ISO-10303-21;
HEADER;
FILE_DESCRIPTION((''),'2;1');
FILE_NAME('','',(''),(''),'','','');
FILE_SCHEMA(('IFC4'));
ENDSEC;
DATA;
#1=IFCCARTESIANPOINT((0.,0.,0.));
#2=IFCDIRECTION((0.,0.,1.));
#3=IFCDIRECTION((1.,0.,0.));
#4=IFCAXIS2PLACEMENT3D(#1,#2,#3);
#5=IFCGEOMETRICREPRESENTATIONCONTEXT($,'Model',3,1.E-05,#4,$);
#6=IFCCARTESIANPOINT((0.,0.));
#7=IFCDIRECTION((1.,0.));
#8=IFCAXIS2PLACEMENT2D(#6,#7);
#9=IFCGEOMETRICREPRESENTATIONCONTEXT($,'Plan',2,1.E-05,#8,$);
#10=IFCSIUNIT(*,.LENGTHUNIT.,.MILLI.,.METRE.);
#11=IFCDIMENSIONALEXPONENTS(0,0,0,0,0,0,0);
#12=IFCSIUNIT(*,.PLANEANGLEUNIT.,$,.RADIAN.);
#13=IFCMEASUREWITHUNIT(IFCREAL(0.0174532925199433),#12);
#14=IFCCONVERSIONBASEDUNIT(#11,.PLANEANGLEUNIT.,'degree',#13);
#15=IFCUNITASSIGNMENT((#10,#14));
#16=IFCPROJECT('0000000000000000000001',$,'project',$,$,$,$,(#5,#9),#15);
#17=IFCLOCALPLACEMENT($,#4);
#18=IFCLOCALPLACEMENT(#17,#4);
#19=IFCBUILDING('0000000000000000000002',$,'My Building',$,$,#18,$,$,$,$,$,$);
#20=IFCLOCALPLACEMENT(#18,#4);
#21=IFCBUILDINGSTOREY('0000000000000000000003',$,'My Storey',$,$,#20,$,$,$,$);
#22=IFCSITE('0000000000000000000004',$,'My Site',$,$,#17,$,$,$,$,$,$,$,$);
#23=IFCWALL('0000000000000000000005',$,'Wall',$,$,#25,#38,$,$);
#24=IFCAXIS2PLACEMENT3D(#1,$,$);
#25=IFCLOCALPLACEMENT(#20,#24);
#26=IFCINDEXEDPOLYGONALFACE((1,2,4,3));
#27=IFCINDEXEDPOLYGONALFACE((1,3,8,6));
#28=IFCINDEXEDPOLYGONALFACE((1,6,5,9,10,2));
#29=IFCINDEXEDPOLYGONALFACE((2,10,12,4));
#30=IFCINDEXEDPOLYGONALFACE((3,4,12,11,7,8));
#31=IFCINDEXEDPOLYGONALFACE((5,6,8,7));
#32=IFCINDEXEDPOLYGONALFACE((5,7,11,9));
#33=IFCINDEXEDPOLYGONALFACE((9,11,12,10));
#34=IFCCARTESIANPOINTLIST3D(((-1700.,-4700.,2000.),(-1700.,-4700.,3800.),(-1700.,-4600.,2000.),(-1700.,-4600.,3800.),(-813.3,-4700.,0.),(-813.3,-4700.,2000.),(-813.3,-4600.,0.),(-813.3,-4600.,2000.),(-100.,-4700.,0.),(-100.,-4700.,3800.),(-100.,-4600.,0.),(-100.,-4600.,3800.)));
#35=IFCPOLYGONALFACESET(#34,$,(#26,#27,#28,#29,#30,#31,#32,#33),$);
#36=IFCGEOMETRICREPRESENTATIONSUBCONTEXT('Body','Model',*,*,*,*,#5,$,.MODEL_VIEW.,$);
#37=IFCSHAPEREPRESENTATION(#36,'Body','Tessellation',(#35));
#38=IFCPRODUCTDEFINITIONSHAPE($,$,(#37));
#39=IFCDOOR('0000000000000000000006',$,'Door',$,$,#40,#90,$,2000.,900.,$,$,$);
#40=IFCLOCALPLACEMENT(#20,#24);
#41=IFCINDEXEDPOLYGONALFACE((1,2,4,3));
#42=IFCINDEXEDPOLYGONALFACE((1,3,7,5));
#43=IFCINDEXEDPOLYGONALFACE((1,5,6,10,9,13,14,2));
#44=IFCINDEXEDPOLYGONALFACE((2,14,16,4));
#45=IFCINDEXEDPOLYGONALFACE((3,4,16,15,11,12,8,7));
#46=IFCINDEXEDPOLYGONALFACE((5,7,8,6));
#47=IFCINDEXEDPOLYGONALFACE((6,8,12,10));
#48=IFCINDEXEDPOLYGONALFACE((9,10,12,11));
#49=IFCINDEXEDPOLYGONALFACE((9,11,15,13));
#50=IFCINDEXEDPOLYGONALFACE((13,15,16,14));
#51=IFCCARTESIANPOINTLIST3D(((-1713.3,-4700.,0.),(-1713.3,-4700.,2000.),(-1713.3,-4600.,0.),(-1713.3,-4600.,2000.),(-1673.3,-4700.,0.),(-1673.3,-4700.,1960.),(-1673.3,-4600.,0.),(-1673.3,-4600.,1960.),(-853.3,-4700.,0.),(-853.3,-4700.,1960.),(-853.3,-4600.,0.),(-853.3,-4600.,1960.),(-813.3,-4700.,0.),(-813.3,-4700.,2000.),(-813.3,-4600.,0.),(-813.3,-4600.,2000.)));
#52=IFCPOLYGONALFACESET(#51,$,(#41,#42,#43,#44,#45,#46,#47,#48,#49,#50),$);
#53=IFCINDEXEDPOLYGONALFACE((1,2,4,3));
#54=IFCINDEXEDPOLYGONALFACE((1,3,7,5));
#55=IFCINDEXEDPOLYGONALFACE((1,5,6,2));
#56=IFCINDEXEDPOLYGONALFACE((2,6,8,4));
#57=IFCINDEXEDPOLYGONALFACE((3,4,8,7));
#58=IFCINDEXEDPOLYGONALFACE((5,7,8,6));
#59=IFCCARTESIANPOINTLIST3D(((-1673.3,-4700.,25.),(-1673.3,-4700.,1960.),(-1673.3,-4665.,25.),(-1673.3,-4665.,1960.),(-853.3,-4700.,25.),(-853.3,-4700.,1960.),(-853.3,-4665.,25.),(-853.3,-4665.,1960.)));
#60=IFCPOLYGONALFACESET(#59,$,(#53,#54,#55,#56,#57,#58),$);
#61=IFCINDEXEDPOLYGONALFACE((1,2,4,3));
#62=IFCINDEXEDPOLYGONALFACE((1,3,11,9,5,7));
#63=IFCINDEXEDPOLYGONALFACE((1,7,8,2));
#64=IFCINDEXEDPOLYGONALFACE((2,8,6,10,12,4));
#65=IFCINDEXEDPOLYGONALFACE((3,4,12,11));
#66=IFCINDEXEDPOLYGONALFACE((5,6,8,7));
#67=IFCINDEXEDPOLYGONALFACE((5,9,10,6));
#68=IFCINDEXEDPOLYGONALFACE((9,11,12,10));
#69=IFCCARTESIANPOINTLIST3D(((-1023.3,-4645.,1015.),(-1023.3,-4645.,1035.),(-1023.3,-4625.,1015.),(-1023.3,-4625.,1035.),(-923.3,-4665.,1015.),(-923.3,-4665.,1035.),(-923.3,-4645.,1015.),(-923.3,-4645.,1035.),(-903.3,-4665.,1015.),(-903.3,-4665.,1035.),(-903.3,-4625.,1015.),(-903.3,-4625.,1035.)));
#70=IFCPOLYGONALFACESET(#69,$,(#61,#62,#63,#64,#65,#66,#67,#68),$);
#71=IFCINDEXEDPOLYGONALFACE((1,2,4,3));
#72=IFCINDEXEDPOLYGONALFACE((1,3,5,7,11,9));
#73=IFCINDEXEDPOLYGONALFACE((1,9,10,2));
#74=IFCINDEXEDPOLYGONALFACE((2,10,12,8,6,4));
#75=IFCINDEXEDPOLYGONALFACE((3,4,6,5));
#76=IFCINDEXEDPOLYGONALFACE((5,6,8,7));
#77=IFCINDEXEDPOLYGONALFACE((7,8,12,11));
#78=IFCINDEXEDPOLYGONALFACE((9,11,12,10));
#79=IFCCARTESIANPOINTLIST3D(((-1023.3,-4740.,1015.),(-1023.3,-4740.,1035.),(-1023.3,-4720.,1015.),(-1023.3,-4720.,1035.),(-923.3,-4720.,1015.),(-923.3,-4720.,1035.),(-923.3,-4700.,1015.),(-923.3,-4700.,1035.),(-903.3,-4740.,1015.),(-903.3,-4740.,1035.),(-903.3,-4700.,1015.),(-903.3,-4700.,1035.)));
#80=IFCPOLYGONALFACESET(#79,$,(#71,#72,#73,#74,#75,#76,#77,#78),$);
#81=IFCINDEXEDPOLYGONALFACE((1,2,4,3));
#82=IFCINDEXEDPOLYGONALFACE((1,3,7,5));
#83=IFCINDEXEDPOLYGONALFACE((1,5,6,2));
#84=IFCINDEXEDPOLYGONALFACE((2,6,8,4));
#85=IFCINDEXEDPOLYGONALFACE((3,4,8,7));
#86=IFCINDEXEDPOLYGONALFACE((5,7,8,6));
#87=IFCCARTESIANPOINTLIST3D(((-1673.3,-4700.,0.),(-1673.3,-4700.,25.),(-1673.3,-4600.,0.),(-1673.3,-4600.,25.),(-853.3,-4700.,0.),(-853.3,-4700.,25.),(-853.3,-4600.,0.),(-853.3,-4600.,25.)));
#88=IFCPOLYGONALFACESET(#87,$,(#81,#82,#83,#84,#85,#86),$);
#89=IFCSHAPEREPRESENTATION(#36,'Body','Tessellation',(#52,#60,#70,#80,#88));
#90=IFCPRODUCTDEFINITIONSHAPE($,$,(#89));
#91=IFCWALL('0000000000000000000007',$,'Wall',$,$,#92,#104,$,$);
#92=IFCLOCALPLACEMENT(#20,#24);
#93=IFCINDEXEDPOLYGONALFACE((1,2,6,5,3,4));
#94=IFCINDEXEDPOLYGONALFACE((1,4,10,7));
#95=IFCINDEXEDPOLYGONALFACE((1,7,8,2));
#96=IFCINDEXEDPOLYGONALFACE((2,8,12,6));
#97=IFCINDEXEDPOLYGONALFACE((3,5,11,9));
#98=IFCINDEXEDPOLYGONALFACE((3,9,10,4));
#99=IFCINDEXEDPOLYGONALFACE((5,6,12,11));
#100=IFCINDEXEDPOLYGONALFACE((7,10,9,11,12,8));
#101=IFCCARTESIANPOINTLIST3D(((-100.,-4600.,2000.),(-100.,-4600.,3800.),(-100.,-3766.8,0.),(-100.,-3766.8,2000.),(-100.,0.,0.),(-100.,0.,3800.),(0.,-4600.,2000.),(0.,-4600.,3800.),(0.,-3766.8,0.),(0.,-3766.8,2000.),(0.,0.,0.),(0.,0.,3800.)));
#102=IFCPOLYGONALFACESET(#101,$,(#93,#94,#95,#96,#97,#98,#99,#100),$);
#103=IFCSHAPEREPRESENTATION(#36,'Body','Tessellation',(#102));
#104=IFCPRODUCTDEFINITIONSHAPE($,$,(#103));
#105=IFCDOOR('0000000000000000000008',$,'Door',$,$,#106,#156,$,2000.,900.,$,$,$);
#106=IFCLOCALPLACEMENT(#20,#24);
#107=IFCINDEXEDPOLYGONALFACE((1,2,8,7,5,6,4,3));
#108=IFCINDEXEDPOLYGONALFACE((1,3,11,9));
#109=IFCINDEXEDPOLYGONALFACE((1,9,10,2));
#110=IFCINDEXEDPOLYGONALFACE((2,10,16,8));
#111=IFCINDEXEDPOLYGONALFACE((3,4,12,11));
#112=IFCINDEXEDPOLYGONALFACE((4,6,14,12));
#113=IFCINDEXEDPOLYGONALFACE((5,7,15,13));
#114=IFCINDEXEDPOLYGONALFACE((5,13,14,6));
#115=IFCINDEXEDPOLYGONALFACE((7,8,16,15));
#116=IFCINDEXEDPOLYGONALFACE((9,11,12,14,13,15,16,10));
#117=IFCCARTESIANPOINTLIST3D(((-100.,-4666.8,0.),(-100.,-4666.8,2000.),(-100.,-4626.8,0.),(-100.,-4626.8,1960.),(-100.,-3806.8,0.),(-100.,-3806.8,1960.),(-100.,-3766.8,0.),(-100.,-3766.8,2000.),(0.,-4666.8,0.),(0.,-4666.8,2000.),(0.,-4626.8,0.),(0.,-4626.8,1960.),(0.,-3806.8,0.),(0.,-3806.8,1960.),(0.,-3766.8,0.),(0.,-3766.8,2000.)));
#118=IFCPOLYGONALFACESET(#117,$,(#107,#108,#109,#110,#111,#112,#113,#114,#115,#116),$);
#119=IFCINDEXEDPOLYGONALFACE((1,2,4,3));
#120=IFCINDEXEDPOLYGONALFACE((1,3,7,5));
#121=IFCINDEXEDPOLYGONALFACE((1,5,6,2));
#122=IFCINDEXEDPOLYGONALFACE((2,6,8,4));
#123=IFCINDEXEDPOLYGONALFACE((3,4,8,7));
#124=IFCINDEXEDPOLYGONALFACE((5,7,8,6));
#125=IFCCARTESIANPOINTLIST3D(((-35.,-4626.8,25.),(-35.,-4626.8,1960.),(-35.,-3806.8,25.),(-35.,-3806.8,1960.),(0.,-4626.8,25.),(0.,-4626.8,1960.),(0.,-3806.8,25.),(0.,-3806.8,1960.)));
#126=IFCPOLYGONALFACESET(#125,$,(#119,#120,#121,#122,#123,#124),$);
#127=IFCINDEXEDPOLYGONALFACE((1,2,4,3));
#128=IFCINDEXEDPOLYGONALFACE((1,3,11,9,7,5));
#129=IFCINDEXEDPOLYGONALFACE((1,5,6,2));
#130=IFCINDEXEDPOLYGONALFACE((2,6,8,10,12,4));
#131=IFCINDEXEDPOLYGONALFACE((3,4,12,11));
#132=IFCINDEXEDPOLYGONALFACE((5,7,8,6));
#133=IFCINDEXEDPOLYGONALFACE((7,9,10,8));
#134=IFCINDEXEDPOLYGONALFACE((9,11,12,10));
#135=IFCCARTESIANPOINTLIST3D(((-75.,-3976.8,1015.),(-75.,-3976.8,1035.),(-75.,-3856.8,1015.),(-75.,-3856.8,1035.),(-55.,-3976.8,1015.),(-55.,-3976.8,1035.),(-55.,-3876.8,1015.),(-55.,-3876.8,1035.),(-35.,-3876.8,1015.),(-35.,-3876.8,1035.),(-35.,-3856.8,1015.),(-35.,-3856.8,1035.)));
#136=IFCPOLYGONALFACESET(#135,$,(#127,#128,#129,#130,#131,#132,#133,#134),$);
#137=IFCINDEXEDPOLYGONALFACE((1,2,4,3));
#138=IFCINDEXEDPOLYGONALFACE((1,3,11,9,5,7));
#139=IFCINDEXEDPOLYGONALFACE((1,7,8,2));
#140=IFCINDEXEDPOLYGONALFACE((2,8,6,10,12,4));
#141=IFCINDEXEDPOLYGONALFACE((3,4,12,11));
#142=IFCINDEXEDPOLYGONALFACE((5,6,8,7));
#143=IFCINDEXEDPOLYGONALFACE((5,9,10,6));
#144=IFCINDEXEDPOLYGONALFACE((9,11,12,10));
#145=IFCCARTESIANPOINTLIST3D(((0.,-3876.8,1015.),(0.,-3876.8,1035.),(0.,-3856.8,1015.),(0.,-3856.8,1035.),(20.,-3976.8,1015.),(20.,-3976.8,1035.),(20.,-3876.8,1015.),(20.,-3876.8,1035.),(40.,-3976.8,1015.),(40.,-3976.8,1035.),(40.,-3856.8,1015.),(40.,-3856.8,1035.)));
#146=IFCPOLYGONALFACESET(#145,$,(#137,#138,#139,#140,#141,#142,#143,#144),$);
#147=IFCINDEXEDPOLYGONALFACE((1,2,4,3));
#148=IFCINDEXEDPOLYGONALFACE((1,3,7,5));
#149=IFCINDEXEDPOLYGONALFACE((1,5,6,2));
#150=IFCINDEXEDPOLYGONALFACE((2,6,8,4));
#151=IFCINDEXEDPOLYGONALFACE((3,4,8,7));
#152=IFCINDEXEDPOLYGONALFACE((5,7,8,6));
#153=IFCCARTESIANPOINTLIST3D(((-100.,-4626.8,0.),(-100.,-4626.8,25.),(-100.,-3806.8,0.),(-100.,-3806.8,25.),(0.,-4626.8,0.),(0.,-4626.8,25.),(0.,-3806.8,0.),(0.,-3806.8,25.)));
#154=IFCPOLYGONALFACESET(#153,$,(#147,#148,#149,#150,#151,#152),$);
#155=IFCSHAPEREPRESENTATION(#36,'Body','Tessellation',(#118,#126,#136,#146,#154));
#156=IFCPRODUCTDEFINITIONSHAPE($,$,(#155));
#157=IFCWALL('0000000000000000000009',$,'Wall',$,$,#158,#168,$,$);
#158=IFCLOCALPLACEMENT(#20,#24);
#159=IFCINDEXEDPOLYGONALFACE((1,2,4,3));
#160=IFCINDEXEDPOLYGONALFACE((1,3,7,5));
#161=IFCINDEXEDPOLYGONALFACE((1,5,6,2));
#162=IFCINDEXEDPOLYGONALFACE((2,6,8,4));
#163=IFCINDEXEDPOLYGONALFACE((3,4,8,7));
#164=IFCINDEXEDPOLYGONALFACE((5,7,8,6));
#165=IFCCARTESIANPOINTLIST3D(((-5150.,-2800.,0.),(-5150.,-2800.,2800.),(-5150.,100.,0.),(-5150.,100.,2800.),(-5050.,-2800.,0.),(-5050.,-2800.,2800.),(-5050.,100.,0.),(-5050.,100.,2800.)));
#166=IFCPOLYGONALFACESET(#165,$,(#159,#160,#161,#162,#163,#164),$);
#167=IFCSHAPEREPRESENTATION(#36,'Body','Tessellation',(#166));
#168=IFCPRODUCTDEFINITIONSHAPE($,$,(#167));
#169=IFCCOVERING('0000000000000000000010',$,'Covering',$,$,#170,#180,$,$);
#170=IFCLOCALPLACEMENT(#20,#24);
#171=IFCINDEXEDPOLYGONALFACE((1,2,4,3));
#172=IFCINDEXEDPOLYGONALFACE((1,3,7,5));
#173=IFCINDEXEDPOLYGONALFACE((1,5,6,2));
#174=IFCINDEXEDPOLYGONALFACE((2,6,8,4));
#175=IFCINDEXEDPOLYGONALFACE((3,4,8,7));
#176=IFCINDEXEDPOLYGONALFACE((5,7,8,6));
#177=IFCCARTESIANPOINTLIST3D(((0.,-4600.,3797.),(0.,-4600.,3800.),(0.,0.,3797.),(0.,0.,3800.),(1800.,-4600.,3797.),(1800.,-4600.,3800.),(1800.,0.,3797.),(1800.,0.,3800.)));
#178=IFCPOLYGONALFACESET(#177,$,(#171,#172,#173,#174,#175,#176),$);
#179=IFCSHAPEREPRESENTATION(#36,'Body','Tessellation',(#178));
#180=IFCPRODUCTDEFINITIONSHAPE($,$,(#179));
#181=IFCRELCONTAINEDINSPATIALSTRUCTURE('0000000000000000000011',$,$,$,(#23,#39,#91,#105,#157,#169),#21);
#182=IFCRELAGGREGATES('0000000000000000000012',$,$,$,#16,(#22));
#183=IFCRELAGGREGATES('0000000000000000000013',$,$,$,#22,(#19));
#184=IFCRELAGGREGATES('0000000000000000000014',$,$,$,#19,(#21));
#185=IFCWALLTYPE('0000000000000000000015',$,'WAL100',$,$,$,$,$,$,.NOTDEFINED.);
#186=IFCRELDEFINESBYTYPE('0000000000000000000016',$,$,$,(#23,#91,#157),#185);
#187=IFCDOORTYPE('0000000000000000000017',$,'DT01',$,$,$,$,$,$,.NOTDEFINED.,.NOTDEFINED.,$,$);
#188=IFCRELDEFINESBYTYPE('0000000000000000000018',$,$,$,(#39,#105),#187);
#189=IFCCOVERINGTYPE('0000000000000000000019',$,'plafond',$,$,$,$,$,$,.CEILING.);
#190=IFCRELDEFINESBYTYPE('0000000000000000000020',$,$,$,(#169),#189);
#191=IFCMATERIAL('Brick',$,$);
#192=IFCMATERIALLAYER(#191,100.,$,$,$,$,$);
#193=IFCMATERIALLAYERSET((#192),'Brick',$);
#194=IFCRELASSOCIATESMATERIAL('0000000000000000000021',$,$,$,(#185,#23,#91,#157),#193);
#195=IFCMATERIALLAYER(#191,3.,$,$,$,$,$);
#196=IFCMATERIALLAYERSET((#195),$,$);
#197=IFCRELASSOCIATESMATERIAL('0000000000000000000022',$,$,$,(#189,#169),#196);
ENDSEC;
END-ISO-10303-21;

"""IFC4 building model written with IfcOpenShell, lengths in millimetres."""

from ifc_helpers import new_model, entity, si_unit, converted_unit, frame, origin_with_axes, origin_2d_with_axis, place, context, subcontext, project, spatial, line, indexed_curve, outline, extrude, shape, source, transform, mapped, material, layer, layer_set, layer_usage, type_object, type_shapes, element, fill, save


model = new_model("IFC4")

# Units and contexts
model_context = context("Model", 3, precision=1e-05, world=origin_with_axes())
plan_context = context("Plan", 2, precision=1e-05, world=origin_2d_with_axis())
body_context_1 = subcontext(model_context, "Body", "Model", "MODEL_VIEW")
body_context_2 = subcontext(plan_context, "Body", "Plan", "PLAN_VIEW")
ifc_project = project(units=[si_unit("LENGTHUNIT", "METRE", prefix="MILLI"), converted_unit("PLANEANGLEUNIT", "degree", entity("IfcReal", 0.0174532925199433), si_unit("PLANEANGLEUNIT", "RADIAN"), dimensions=[0, 0, 0, 0, 0, 0, 0])], contexts=[model_context, plan_context])

# Site, building, storey
site_placement = place(None, origin_with_axes())
site = spatial("IfcSite", under=ifc_project, at=site_placement, Name="My Site")
building_placement = place(site_placement, origin_with_axes())
building = spatial("IfcBuilding", under=site, at=building_placement, Name="My Building")
storey_placement = place(building_placement, origin_with_axes())
storey = spatial("IfcBuildingStorey", under=building, at=storey_placement, Name="My Storey")

# Shared definitions
ifc_material = material(Name="Brick")
ifc_layer_1 = layer(ifc_material, 100.0)
ifc_layer_set_1 = layer_set([ifc_layer_1], Name="Brick")
wall_type = type_object("IfcWallType", Name="WAL100", PredefinedType="NOTDEFINED", material=ifc_layer_set_1)

# Shared definitions
shared_shape_1 = source(origin_with_axes(), body_context_1, "Body", "SweptSolid", [
    extrude(outline(indexed_curve([(0.0, 0.0), (900.0, 0.0), (900.0, 2000.0), (0.0, 2000.0)], segments=[line(1, 2, 3, 4, 1)])), frame((0.0, -100.0, 0.0), z_axis=(0.0, -1.0, 0.0), x_axis=(1.0, 0.0, 0.0)), (0.0, 0.0, -1.0), 300.0),
])
door_type_1 = type_object("IfcDoorType", Name="DT01", OperationType="NOTDEFINED", PredefinedType="NOTDEFINED")
shared_shape_2 = source(origin_with_axes(), body_context_1, "Body", "SweptSolid", [
    extrude(outline(indexed_curve([(0.0, 0.0), (0.0, 2000.0), (900.0, 2000.0), (900.0, 0.0), (860.0, 0.0), (860.0, 1960.0), (40.0, 1960.0), (40.0, 0.0)], segments=[line(1, 2, 3, 4, 5, 6, 7, 8, 1)])), frame((0.0, 0.0, 0.0), z_axis=(0.0, -1.0, 0.0), x_axis=(1.0, 0.0, 0.0)), (0.0, 0.0, -1.0), 100.0),
    extrude(outline(indexed_curve([(0.0, 0.0), (820.0, 0.0), (820.0, 35.0), (0.0, 35.0)], segments=[line(1, 2, 3, 4, 1)])), frame((40.0, 65.0, 25.0), z_axis=(0.0, 0.0, 1.0), x_axis=(1.0, 0.0, 0.0)), (0.0, 0.0, 1.0), 1935.0),
    extrude(outline(indexed_curve([(0.0, 0.0), (0.0, -40.0), (120.0, -40.0), (120.0, -20.0), (20.0, -20.0), (20.0, 0.0)], segments=[line(1, 2, 3, 4, 5, 6, 1)])), frame((90.0, 65.0, 1015.0), z_axis=(0.0, 0.0, 1.0), x_axis=(1.0, 0.0, 0.0)), (0.0, 0.0, 1.0), 20.0),
    extrude(outline(indexed_curve([(0.0, 0.0), (0.0, 40.0), (120.0, 40.0), (120.0, 20.0), (20.0, 20.0), (20.0, 0.0)], segments=[line(1, 2, 3, 4, 5, 6, 1)])), frame((90.0, 100.0, 1015.0), z_axis=(0.0, 0.0, 1.0), x_axis=(1.0, 0.0, 0.0)), (0.0, 0.0, 1.0), 20.0),
    extrude(outline(indexed_curve([(0.0, 0.0), (820.0, 0.0), (820.0, 100.0), (0.0, 100.0)], segments=[line(1, 2, 3, 4, 1)])), frame((40.0, 0.0, 0.0), z_axis=(0.0, 0.0, 1.0), x_axis=(1.0, 0.0, 0.0)), (0.0, 0.0, 1.0), 25.0),
])
shared_shape_3 = source(origin_with_axes(), body_context_2, "Body", "Curve2D", [
    entity("IfcIndexedPolyCurve", entity("IfcCartesianPointList2D", [[0.0, 0.0], [40.0, 0.0], [40.0, 100.0], [0.0, 100.0]]), [entity("IfcLineIndex", [1, 2, 3, 4, 1])]),
    entity("IfcIndexedPolyCurve", entity("IfcCartesianPointList2D", [[900.0, 0.0], [860.0, 0.0], [860.0, 100.0], [900.0, 100.0]]), [entity("IfcLineIndex", [1, 2, 3, 4, 1])]),
    entity("IfcTrimmedCurve", entity("IfcEllipse", entity("IfcAxis2Placement2D", entity("IfcCartesianPoint", [825.0, 100.0]), entity("IfcDirection", [1.0, 0.0])), 785.0, 820.0), [entity("IfcCartesianPoint", [825.0, 920.0])], [entity("IfcCartesianPoint", [40.0, 100.0])], True, "CARTESIAN"),
    entity("IfcIndexedPolyCurve", entity("IfcCartesianPointList2D", [[860.0, 100.0], [825.0, 100.0], [825.0, 920.0], [860.0, 920.0]]), [entity("IfcLineIndex", [1, 2, 3, 4, 1])]),
])
type_shapes(door_type_1, [shared_shape_2, shared_shape_3])

# Walls, openings, doors
ifc_layer_usage_1 = layer_usage(ifc_layer_set_1, "AXIS2", "POSITIVE", 0.0)
wall_1_placement = place(storey_placement, frame((-100.0, -4600.0, 0.0), z_axis=(0.0, 0.0, 1.0), x_axis=(-1.0, 0.0, 0.0)))
wall_1 = element("IfcWall", 1, at=wall_1_placement, inside=storey, type_object=wall_type, material=ifc_layer_usage_1, Name="Wall", context=body_context_1, shape_type="SweptSolid", body=[
    extrude(outline(indexed_curve([(0.0, 0.0), (0.0, 100.0), (1600.0, 100.0), (1600.0, 0.0), (0.0, 0.0)], self_intersect=False)), origin_with_axes(), (0.0, 0.0, 1.0), 3800.0),
])
opening_1_placement = place(wall_1_placement, frame((713.3, 0.0, 0.0), z_axis=(0.0, 0.0, 1.0), x_axis=(1.0, 0.0, 0.0)))
opening_1 = element("IfcOpeningElement", 2, at=opening_1_placement, cuts=wall_1, PredefinedType="OPENING", context=body_context_1, shape_type="MappedRepresentation", body=[
    mapped(shared_shape_1, transform((0.0, 0.0, 0.0), x_axis=(1.0, 0.0, 0.0), y_axis=(0.0, 1.0, 0.0), z_axis=(0.0, 0.0, 1.0), scale=1.0)),
])
door_1_placement = place(opening_1_placement, frame((0.0, 0.0, 0.0), z_axis=(0.0, 0.0, 1.0), x_axis=(1.0, 0.0, 0.0)))
door_1 = element("IfcDoor", 3, at=door_1_placement, inside=storey, type_object=door_type_1, Name="Door", OverallHeight=2000.0, OverallWidth=900.0, shapes=[
    shape(body_context_1, "Body", "MappedRepresentation", [mapped(shared_shape_2, transform((0.0, 0.0, 0.0), x_axis=(1.0, 0.0, 0.0), y_axis=(0.0, 1.0, 0.0), z_axis=(0.0, 0.0, 1.0), scale=1.0))]),
    shape(body_context_2, "Body", "MappedRepresentation", [mapped(shared_shape_3, transform((0.0, 0.0, 0.0), x_axis=(1.0, 0.0, 0.0), y_axis=(0.0, 1.0, 0.0), z_axis=(0.0, 0.0, 1.0), scale=1.0))]),
])
fill(opening_1, door_1)
ifc_layer_usage_2 = layer_usage(ifc_layer_set_1, "AXIS2", "POSITIVE", 0.0)
wall_2_placement = place(storey_placement, frame((-100.0, 0.0, 0.0), z_axis=(0.0, 0.0, 1.0), x_axis=(-0.000001, -1.0, 0.0)))
wall_2 = element("IfcWall", 4, at=wall_2_placement, inside=storey, type_object=wall_type, material=ifc_layer_usage_2, Name="Wall", context=body_context_1, shape_type="SweptSolid", body=[
    extrude(outline(indexed_curve([(0.0, 0.0), (0.0, 100.0), (4600.0, 100.0), (4600.0, 0.0), (0.0, 0.0)], self_intersect=False)), origin_with_axes(), (0.0, 0.0, 1.0), 3800.0),
])
opening_2_placement = place(wall_2_placement, frame((3766.8, 0.0, 0.0), z_axis=(0.0, 0.0, 1.0), x_axis=(1.0, 0.0, 0.0)))
opening_2 = element("IfcOpeningElement", 5, at=opening_2_placement, cuts=wall_2, PredefinedType="OPENING", context=body_context_1, shape_type="MappedRepresentation", body=[
    mapped(shared_shape_1, transform((0.0, 0.0, 0.0), x_axis=(1.0, 0.0, 0.0), y_axis=(0.0, 1.0, 0.0), z_axis=(0.0, 0.0, 1.0), scale=1.0)),
])
door_2_placement = place(opening_2_placement, frame((0.0, 0.0, 0.0), z_axis=(0.0, 0.0, 1.0), x_axis=(1.0, 0.0, 0.0)))
door_2 = element("IfcDoor", 6, at=door_2_placement, inside=storey, type_object=door_type_1, Name="Door", OverallHeight=2000.0, OverallWidth=900.0, shapes=[
    shape(body_context_1, "Body", "MappedRepresentation", [mapped(shared_shape_2, transform((0.0, 0.0, 0.0), x_axis=(1.0, 0.0, 0.0), y_axis=(0.0, 1.0, 0.0), z_axis=(0.0, 0.0, 1.0), scale=1.0))]),
    shape(body_context_2, "Body", "MappedRepresentation", [mapped(shared_shape_3, transform((0.0, 0.0, 0.0), x_axis=(1.0, 0.0, 0.0), y_axis=(0.0, 1.0, 0.0), z_axis=(0.0, 0.0, 1.0), scale=1.0))]),
])
fill(opening_2, door_2)

# Wall
ifc_layer_usage_3 = layer_usage(ifc_layer_set_1, "AXIS2", "POSITIVE", 0.0)
wall_3_placement = place(storey_placement, frame((-5050.0, -2800.0, 0.0), z_axis=(0.0, 0.0, 1.0), x_axis=(0.000004, 1.0, 0.0)))
element("IfcWall", 7, at=wall_3_placement, inside=storey, type_object=wall_type, material=ifc_layer_usage_3, Name="Wall", context=body_context_1, shape_type="SweptSolid", body=[
    extrude(outline(indexed_curve([(0.0, 0.0), (0.0, 100.0), (2900.0, 100.0), (2900.0, 0.0), (0.0, 0.0)], self_intersect=False)), origin_with_axes(), (0.0, 0.0, 1.0), 2800.0),
])

# Covering
ifc_layer_2 = layer(ifc_material, 3.0)
ifc_layer_set_2 = layer_set([ifc_layer_2])
covering_type = type_object("IfcCoveringType", Name="plafond", PredefinedType="CEILING", material=ifc_layer_set_2)
ifc_layer_usage_4 = layer_usage(ifc_layer_set_2, "AXIS3", "POSITIVE", 0.0)
covering_1_placement = place(storey_placement, frame((0.0, -4600.0, 3797.0), z_axis=(0.0, 0.0, 1.0), x_axis=(1.0, 0.0, 0.0)))
element("IfcCovering", 8, at=covering_1_placement, inside=storey, type_object=covering_type, material=ifc_layer_usage_4, Name="Covering", context=body_context_1, shape_type="SweptSolid", body=[
    extrude(outline(indexed_curve([(0.0, 0.0), (1800.0, 0.0), (1800.0, 4600.0), (0.0, 4600.0)], segments=[line(3, 2), line(2, 1), line(1, 4), line(4, 3)], self_intersect=False)), None, (0.0, 0.0, 1.0), 3.0),
])

save(model, "model.ifc")
